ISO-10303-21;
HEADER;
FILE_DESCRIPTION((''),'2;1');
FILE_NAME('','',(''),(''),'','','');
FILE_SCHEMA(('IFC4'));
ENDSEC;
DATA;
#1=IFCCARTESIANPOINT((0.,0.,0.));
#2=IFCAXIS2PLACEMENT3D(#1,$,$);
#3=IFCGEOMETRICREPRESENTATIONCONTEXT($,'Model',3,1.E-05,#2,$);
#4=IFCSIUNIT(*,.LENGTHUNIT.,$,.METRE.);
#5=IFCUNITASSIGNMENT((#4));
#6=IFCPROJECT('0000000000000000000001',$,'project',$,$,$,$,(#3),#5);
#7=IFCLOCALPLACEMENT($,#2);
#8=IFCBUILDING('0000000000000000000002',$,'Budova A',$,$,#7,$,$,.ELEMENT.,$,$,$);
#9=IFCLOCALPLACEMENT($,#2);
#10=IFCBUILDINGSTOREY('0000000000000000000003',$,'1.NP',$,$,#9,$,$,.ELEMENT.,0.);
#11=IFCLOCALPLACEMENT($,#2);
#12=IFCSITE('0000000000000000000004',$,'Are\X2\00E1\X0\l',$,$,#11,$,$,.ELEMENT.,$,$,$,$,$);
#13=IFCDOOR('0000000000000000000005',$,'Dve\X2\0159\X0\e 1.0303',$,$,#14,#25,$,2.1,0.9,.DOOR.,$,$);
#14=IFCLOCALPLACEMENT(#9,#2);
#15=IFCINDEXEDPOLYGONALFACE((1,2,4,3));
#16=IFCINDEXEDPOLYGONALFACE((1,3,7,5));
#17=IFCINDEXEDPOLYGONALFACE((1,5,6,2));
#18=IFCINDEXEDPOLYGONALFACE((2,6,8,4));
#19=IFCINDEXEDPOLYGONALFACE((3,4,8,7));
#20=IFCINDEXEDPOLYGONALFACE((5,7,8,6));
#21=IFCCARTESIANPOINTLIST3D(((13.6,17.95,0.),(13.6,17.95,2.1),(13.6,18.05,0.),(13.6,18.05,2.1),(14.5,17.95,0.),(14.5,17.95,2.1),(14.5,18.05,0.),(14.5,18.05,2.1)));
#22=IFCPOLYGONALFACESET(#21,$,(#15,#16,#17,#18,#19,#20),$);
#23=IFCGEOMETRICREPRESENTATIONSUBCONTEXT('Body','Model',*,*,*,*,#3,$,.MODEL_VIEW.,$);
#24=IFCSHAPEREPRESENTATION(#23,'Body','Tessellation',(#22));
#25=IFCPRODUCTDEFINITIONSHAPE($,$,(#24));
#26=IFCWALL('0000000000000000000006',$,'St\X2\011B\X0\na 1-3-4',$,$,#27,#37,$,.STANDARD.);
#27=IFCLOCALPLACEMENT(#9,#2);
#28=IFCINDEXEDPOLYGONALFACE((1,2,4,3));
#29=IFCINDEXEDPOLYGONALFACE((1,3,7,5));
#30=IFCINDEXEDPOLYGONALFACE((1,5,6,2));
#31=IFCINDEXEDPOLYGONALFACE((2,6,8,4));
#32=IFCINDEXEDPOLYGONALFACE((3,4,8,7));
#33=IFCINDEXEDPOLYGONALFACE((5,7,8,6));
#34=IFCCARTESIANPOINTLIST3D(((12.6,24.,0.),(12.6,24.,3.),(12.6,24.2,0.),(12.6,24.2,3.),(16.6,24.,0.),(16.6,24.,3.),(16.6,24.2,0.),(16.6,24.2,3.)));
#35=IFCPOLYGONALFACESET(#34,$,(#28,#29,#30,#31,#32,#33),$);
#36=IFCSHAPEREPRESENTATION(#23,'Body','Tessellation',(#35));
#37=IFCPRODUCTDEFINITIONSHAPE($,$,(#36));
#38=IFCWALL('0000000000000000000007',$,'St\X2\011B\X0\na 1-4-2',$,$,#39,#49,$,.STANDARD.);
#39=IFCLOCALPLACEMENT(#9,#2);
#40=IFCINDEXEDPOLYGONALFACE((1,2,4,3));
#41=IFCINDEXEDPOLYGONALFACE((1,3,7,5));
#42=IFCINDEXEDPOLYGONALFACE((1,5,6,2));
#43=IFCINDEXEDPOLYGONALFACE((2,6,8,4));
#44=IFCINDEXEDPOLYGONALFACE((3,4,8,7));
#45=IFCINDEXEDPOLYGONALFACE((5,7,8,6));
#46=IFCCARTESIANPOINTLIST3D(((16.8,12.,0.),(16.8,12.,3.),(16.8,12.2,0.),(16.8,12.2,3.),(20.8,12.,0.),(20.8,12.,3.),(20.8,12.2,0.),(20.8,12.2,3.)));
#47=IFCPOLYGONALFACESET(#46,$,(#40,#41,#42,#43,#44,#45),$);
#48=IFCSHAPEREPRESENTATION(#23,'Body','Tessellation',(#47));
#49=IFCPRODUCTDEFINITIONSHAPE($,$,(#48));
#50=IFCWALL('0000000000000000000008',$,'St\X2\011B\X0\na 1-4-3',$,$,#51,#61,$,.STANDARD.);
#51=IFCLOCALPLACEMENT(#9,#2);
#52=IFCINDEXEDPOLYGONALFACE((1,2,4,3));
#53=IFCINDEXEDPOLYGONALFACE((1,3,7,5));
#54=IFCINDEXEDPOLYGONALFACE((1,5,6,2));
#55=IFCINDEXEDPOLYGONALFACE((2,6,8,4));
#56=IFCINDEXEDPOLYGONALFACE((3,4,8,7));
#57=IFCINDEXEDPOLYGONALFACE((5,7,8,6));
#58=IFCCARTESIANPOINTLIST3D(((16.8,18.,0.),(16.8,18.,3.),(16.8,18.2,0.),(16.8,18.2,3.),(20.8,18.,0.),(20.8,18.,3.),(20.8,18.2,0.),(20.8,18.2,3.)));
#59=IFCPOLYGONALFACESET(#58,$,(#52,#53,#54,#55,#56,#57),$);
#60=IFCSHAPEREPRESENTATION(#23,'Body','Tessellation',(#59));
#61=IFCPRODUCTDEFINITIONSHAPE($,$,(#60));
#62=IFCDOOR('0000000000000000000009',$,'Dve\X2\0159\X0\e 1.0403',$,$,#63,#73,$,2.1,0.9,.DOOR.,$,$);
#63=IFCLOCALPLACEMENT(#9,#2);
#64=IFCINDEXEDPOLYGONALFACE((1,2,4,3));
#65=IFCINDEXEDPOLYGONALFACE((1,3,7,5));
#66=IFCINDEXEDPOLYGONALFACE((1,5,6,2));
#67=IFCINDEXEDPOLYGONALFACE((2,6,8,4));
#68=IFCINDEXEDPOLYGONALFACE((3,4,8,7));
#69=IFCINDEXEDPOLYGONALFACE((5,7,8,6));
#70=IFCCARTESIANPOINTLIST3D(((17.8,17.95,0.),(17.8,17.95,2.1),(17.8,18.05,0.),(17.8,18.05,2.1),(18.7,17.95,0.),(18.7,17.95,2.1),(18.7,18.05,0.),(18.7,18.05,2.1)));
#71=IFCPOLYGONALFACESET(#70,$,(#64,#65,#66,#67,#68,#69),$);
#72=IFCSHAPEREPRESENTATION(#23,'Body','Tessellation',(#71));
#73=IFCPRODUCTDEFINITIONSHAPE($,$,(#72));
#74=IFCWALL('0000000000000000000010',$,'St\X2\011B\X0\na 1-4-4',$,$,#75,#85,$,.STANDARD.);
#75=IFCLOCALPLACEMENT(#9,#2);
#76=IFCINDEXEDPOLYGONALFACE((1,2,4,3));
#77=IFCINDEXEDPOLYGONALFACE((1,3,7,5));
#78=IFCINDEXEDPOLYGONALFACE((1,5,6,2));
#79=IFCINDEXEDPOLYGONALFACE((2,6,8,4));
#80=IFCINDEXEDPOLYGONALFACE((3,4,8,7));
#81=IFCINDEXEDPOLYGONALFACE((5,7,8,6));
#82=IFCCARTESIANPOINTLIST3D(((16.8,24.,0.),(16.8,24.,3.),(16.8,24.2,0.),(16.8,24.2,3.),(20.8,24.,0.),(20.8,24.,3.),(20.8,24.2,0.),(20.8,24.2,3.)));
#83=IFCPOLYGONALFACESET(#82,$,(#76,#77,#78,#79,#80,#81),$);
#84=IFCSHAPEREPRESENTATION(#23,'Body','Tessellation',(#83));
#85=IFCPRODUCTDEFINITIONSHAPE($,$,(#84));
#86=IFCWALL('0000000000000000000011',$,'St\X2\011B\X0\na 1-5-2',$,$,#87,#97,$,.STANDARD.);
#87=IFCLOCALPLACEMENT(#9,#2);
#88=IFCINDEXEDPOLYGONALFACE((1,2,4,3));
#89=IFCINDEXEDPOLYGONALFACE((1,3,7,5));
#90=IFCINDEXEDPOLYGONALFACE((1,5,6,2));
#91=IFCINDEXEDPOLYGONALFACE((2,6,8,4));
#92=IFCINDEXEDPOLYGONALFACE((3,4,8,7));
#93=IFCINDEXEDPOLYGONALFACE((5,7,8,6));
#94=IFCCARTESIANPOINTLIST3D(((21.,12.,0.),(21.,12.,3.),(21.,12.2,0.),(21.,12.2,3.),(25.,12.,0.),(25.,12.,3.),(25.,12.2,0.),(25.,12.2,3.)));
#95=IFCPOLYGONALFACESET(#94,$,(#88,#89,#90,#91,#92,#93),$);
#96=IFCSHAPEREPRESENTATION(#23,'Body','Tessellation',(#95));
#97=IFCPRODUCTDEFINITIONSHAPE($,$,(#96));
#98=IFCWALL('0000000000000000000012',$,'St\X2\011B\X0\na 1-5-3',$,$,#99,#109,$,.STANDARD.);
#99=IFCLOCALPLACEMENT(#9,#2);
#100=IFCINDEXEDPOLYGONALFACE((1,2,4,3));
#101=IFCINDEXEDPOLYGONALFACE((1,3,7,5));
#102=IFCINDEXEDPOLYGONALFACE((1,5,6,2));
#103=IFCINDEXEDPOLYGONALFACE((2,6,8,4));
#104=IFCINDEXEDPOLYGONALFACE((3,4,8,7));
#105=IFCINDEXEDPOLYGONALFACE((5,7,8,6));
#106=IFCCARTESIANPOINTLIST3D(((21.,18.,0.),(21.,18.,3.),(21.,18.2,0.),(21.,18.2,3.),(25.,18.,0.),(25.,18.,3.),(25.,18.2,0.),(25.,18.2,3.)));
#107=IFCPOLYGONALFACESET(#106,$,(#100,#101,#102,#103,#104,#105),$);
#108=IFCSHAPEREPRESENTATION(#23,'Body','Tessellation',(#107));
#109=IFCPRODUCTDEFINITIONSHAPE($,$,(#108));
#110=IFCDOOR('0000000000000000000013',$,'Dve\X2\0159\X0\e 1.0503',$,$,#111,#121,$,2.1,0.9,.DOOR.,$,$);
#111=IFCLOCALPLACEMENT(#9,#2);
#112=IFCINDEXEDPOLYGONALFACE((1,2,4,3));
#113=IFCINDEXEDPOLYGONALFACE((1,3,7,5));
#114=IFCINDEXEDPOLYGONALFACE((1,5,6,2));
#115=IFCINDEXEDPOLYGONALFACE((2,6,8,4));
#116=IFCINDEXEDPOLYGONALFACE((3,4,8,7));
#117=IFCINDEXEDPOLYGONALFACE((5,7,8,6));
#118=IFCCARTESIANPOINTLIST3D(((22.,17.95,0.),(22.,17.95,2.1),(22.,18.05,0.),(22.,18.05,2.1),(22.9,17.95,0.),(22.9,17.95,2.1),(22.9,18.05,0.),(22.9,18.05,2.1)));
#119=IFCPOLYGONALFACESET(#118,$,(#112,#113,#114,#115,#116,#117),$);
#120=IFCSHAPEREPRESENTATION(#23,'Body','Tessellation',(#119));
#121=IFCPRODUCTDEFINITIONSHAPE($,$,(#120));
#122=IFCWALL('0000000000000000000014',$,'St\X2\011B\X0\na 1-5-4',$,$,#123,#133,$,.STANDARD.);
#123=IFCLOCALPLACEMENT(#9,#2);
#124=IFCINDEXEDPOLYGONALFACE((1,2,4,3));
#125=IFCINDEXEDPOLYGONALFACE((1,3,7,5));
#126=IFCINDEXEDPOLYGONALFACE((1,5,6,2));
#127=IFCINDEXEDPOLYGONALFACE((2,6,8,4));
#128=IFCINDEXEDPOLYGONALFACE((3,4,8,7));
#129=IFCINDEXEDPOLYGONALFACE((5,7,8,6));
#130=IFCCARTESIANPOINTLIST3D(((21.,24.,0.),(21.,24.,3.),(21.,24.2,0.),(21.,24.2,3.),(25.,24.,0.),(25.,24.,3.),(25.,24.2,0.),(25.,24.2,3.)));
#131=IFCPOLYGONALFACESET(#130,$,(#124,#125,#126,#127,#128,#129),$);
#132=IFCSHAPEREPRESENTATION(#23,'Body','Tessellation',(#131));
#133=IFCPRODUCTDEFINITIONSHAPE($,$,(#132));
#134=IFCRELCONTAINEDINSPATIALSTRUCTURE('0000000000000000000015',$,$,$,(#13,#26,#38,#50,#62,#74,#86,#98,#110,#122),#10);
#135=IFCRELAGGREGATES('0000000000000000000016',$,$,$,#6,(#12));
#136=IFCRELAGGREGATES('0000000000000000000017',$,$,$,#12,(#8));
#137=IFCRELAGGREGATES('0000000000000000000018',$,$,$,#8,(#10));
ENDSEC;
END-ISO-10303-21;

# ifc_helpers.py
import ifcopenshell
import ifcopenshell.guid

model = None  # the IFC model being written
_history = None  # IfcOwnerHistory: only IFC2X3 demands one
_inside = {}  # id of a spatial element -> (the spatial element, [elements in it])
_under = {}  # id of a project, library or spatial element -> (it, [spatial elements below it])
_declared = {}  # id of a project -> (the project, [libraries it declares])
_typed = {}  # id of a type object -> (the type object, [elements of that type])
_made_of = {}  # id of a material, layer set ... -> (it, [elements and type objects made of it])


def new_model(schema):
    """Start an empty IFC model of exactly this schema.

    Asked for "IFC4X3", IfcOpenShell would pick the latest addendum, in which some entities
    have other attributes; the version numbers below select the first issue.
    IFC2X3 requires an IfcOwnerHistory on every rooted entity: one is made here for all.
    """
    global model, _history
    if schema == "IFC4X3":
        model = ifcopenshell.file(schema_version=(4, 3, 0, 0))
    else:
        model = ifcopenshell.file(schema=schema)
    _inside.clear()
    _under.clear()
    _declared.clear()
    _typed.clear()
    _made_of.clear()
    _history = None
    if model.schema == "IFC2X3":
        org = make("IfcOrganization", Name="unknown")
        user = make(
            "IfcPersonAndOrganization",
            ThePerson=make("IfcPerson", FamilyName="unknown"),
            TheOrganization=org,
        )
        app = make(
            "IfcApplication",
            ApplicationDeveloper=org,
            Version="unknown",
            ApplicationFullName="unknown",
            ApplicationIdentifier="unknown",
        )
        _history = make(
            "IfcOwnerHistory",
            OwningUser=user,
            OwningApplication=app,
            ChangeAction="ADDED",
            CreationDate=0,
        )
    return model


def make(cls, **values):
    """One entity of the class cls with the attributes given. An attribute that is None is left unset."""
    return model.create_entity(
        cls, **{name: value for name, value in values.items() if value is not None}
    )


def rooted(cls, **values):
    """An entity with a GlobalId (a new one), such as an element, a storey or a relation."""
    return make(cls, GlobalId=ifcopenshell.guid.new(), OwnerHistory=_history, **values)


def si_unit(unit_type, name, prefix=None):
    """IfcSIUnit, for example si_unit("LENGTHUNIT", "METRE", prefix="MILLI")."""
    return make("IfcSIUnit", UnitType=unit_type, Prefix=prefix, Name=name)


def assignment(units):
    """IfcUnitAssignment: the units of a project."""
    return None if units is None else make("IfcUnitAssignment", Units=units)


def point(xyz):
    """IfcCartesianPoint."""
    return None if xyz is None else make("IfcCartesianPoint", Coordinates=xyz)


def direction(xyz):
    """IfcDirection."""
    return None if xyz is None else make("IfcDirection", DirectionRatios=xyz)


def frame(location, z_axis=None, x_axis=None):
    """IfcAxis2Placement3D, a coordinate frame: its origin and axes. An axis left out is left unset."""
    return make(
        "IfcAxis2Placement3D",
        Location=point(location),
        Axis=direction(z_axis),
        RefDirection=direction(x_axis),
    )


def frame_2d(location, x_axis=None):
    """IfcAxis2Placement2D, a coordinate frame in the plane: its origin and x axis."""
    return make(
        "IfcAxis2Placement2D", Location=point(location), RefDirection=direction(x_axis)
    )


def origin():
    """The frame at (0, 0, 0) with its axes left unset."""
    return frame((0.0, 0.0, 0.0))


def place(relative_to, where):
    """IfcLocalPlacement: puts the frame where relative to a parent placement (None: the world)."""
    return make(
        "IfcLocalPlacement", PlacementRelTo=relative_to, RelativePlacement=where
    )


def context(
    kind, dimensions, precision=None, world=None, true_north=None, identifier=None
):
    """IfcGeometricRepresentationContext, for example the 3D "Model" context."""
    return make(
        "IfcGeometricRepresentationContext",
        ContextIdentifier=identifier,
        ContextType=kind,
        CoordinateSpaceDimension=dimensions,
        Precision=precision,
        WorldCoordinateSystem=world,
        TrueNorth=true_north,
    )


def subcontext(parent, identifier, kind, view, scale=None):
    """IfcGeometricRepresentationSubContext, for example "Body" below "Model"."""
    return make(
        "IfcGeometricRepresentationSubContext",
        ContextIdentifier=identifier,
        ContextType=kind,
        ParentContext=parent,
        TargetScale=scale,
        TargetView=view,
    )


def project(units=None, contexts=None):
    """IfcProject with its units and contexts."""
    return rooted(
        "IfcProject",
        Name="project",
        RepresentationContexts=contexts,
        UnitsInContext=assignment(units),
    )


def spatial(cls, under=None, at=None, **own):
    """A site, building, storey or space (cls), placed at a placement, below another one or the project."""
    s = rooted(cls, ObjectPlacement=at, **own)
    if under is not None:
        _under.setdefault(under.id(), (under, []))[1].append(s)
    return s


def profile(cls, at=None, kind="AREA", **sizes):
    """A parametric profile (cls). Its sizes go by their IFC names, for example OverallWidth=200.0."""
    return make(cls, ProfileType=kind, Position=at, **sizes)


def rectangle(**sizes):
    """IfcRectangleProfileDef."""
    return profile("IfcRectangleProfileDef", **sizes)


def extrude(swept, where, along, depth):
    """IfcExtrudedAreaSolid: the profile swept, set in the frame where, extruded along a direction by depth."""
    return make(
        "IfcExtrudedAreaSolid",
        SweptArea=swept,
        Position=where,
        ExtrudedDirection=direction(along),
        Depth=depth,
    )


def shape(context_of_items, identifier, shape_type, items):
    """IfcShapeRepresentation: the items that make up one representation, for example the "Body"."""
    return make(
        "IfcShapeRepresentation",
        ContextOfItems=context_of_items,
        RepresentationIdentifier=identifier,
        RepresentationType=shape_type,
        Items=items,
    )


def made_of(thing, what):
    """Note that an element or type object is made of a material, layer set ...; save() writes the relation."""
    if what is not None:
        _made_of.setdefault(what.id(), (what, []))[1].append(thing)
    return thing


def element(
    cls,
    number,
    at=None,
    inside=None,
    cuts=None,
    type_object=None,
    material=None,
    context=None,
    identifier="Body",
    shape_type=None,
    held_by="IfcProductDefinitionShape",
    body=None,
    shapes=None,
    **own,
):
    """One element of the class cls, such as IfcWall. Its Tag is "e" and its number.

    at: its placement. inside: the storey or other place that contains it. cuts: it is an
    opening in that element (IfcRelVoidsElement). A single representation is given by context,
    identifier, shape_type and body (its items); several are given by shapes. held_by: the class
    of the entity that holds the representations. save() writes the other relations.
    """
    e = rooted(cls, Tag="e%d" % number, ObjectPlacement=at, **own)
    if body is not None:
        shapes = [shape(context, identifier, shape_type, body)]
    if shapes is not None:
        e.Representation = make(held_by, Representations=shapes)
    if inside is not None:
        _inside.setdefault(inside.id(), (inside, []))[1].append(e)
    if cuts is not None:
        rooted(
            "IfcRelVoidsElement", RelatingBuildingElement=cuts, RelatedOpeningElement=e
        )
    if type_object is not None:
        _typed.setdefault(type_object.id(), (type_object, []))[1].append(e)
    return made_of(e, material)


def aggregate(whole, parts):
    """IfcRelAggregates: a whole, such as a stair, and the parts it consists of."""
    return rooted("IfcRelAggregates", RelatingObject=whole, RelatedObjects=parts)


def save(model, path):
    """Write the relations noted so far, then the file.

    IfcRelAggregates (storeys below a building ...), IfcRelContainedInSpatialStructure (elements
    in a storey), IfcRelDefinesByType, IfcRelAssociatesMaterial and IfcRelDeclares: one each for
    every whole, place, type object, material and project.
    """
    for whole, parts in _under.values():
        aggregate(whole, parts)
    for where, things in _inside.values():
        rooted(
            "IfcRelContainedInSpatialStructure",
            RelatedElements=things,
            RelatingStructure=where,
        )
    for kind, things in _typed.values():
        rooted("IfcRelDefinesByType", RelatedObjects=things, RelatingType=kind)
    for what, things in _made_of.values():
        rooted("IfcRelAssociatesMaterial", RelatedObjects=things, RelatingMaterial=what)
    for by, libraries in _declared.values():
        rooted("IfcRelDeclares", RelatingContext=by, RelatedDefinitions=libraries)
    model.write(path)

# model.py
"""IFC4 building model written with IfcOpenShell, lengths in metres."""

from ifc_helpers import new_model, si_unit, frame, frame_2d, origin, place, context, subcontext, project, spatial, rectangle, extrude, element, save


model = new_model("IFC4")

# Units and contexts
model_context = context("Model", 3, precision=1e-05, world=origin())
body_context = subcontext(model_context, "Body", "Model", "MODEL_VIEW")
ifc_project = project(units=[si_unit("LENGTHUNIT", "METRE")], contexts=[model_context])

# Site, building, storey
site_placement = place(None, origin())
site = spatial("IfcSite", under=ifc_project, at=site_placement, Name="Areál", CompositionType="ELEMENT")
building_placement = place(None, origin())
building = spatial("IfcBuilding", under=site, at=building_placement, Name="Budova A", CompositionType="ELEMENT")
storey_placement = place(None, origin())
storey = spatial("IfcBuildingStorey", under=building, at=storey_placement, Name="1.NP", CompositionType="ELEMENT", Elevation=0.0)

# Door
door_1_placement = place(storey_placement, frame((13.6, 17.95, 0.0)))
element("IfcDoor", 1, at=door_1_placement, inside=storey, Name="Dveře 1.0303", OverallHeight=2.1, OverallWidth=0.9, PredefinedType="DOOR", context=body_context, shape_type="SweptSolid", body=[
    extrude(rectangle(XDim=0.9, YDim=0.1, at=frame_2d((0.45, 0.05))), origin(), (0.0, 0.0, 1.0), 2.1),
])

# Walls
for number, where, name in (
    (2, (12.6, 24.0, 0.0), "Stěna 1-3-4"),
    (3, (16.8, 12.0, 0.0), "Stěna 1-4-2"),
    (4, (16.8, 18.0, 0.0), "Stěna 1-4-3"),
):
    element("IfcWall", number, at=place(storey_placement, frame(where)), inside=storey, Name=name, PredefinedType="STANDARD", context=body_context, shape_type="SweptSolid", body=[
        extrude(rectangle(XDim=4.0, YDim=0.2, at=frame_2d((2.0, 0.1))), origin(), (0.0, 0.0, 1.0), 3.0),
    ])

# Door
door_2_placement = place(storey_placement, frame((17.8, 17.95, 0.0)))
element("IfcDoor", 5, at=door_2_placement, inside=storey, Name="Dveře 1.0403", OverallHeight=2.1, OverallWidth=0.9, PredefinedType="DOOR", context=body_context, shape_type="SweptSolid", body=[
    extrude(rectangle(XDim=0.9, YDim=0.1, at=frame_2d((0.45, 0.05))), origin(), (0.0, 0.0, 1.0), 2.1),
])

# Walls
for number, where, name in (
    (6, (16.8, 24.0, 0.0), "Stěna 1-4-4"),
    (7, (21.0, 12.0, 0.0), "Stěna 1-5-2"),
    (8, (21.0, 18.0, 0.0), "Stěna 1-5-3"),
):
    element("IfcWall", number, at=place(storey_placement, frame(where)), inside=storey, Name=name, PredefinedType="STANDARD", context=body_context, shape_type="SweptSolid", body=[
        extrude(rectangle(XDim=4.0, YDim=0.2, at=frame_2d((2.0, 0.1))), origin(), (0.0, 0.0, 1.0), 3.0),
    ])

# Door
door_3_placement = place(storey_placement, frame((22.0, 17.95, 0.0)))
element("IfcDoor", 9, at=door_3_placement, inside=storey, Name="Dveře 1.0503", OverallHeight=2.1, OverallWidth=0.9, PredefinedType="DOOR", context=body_context, shape_type="SweptSolid", body=[
    extrude(rectangle(XDim=0.9, YDim=0.1, at=frame_2d((0.45, 0.05))), origin(), (0.0, 0.0, 1.0), 2.1),
])

# Wall
wall_1_placement = place(storey_placement, frame((21.0, 24.0, 0.0)))
element("IfcWall", 10, at=wall_1_placement, inside=storey, Name="Stěna 1-5-4", PredefinedType="STANDARD", context=body_context, shape_type="SweptSolid", body=[
    extrude(rectangle(XDim=4.0, YDim=0.2, at=frame_2d((2.0, 0.1))), origin(), (0.0, 0.0, 1.0), 3.0),
])

save(model, "model.ifc")
